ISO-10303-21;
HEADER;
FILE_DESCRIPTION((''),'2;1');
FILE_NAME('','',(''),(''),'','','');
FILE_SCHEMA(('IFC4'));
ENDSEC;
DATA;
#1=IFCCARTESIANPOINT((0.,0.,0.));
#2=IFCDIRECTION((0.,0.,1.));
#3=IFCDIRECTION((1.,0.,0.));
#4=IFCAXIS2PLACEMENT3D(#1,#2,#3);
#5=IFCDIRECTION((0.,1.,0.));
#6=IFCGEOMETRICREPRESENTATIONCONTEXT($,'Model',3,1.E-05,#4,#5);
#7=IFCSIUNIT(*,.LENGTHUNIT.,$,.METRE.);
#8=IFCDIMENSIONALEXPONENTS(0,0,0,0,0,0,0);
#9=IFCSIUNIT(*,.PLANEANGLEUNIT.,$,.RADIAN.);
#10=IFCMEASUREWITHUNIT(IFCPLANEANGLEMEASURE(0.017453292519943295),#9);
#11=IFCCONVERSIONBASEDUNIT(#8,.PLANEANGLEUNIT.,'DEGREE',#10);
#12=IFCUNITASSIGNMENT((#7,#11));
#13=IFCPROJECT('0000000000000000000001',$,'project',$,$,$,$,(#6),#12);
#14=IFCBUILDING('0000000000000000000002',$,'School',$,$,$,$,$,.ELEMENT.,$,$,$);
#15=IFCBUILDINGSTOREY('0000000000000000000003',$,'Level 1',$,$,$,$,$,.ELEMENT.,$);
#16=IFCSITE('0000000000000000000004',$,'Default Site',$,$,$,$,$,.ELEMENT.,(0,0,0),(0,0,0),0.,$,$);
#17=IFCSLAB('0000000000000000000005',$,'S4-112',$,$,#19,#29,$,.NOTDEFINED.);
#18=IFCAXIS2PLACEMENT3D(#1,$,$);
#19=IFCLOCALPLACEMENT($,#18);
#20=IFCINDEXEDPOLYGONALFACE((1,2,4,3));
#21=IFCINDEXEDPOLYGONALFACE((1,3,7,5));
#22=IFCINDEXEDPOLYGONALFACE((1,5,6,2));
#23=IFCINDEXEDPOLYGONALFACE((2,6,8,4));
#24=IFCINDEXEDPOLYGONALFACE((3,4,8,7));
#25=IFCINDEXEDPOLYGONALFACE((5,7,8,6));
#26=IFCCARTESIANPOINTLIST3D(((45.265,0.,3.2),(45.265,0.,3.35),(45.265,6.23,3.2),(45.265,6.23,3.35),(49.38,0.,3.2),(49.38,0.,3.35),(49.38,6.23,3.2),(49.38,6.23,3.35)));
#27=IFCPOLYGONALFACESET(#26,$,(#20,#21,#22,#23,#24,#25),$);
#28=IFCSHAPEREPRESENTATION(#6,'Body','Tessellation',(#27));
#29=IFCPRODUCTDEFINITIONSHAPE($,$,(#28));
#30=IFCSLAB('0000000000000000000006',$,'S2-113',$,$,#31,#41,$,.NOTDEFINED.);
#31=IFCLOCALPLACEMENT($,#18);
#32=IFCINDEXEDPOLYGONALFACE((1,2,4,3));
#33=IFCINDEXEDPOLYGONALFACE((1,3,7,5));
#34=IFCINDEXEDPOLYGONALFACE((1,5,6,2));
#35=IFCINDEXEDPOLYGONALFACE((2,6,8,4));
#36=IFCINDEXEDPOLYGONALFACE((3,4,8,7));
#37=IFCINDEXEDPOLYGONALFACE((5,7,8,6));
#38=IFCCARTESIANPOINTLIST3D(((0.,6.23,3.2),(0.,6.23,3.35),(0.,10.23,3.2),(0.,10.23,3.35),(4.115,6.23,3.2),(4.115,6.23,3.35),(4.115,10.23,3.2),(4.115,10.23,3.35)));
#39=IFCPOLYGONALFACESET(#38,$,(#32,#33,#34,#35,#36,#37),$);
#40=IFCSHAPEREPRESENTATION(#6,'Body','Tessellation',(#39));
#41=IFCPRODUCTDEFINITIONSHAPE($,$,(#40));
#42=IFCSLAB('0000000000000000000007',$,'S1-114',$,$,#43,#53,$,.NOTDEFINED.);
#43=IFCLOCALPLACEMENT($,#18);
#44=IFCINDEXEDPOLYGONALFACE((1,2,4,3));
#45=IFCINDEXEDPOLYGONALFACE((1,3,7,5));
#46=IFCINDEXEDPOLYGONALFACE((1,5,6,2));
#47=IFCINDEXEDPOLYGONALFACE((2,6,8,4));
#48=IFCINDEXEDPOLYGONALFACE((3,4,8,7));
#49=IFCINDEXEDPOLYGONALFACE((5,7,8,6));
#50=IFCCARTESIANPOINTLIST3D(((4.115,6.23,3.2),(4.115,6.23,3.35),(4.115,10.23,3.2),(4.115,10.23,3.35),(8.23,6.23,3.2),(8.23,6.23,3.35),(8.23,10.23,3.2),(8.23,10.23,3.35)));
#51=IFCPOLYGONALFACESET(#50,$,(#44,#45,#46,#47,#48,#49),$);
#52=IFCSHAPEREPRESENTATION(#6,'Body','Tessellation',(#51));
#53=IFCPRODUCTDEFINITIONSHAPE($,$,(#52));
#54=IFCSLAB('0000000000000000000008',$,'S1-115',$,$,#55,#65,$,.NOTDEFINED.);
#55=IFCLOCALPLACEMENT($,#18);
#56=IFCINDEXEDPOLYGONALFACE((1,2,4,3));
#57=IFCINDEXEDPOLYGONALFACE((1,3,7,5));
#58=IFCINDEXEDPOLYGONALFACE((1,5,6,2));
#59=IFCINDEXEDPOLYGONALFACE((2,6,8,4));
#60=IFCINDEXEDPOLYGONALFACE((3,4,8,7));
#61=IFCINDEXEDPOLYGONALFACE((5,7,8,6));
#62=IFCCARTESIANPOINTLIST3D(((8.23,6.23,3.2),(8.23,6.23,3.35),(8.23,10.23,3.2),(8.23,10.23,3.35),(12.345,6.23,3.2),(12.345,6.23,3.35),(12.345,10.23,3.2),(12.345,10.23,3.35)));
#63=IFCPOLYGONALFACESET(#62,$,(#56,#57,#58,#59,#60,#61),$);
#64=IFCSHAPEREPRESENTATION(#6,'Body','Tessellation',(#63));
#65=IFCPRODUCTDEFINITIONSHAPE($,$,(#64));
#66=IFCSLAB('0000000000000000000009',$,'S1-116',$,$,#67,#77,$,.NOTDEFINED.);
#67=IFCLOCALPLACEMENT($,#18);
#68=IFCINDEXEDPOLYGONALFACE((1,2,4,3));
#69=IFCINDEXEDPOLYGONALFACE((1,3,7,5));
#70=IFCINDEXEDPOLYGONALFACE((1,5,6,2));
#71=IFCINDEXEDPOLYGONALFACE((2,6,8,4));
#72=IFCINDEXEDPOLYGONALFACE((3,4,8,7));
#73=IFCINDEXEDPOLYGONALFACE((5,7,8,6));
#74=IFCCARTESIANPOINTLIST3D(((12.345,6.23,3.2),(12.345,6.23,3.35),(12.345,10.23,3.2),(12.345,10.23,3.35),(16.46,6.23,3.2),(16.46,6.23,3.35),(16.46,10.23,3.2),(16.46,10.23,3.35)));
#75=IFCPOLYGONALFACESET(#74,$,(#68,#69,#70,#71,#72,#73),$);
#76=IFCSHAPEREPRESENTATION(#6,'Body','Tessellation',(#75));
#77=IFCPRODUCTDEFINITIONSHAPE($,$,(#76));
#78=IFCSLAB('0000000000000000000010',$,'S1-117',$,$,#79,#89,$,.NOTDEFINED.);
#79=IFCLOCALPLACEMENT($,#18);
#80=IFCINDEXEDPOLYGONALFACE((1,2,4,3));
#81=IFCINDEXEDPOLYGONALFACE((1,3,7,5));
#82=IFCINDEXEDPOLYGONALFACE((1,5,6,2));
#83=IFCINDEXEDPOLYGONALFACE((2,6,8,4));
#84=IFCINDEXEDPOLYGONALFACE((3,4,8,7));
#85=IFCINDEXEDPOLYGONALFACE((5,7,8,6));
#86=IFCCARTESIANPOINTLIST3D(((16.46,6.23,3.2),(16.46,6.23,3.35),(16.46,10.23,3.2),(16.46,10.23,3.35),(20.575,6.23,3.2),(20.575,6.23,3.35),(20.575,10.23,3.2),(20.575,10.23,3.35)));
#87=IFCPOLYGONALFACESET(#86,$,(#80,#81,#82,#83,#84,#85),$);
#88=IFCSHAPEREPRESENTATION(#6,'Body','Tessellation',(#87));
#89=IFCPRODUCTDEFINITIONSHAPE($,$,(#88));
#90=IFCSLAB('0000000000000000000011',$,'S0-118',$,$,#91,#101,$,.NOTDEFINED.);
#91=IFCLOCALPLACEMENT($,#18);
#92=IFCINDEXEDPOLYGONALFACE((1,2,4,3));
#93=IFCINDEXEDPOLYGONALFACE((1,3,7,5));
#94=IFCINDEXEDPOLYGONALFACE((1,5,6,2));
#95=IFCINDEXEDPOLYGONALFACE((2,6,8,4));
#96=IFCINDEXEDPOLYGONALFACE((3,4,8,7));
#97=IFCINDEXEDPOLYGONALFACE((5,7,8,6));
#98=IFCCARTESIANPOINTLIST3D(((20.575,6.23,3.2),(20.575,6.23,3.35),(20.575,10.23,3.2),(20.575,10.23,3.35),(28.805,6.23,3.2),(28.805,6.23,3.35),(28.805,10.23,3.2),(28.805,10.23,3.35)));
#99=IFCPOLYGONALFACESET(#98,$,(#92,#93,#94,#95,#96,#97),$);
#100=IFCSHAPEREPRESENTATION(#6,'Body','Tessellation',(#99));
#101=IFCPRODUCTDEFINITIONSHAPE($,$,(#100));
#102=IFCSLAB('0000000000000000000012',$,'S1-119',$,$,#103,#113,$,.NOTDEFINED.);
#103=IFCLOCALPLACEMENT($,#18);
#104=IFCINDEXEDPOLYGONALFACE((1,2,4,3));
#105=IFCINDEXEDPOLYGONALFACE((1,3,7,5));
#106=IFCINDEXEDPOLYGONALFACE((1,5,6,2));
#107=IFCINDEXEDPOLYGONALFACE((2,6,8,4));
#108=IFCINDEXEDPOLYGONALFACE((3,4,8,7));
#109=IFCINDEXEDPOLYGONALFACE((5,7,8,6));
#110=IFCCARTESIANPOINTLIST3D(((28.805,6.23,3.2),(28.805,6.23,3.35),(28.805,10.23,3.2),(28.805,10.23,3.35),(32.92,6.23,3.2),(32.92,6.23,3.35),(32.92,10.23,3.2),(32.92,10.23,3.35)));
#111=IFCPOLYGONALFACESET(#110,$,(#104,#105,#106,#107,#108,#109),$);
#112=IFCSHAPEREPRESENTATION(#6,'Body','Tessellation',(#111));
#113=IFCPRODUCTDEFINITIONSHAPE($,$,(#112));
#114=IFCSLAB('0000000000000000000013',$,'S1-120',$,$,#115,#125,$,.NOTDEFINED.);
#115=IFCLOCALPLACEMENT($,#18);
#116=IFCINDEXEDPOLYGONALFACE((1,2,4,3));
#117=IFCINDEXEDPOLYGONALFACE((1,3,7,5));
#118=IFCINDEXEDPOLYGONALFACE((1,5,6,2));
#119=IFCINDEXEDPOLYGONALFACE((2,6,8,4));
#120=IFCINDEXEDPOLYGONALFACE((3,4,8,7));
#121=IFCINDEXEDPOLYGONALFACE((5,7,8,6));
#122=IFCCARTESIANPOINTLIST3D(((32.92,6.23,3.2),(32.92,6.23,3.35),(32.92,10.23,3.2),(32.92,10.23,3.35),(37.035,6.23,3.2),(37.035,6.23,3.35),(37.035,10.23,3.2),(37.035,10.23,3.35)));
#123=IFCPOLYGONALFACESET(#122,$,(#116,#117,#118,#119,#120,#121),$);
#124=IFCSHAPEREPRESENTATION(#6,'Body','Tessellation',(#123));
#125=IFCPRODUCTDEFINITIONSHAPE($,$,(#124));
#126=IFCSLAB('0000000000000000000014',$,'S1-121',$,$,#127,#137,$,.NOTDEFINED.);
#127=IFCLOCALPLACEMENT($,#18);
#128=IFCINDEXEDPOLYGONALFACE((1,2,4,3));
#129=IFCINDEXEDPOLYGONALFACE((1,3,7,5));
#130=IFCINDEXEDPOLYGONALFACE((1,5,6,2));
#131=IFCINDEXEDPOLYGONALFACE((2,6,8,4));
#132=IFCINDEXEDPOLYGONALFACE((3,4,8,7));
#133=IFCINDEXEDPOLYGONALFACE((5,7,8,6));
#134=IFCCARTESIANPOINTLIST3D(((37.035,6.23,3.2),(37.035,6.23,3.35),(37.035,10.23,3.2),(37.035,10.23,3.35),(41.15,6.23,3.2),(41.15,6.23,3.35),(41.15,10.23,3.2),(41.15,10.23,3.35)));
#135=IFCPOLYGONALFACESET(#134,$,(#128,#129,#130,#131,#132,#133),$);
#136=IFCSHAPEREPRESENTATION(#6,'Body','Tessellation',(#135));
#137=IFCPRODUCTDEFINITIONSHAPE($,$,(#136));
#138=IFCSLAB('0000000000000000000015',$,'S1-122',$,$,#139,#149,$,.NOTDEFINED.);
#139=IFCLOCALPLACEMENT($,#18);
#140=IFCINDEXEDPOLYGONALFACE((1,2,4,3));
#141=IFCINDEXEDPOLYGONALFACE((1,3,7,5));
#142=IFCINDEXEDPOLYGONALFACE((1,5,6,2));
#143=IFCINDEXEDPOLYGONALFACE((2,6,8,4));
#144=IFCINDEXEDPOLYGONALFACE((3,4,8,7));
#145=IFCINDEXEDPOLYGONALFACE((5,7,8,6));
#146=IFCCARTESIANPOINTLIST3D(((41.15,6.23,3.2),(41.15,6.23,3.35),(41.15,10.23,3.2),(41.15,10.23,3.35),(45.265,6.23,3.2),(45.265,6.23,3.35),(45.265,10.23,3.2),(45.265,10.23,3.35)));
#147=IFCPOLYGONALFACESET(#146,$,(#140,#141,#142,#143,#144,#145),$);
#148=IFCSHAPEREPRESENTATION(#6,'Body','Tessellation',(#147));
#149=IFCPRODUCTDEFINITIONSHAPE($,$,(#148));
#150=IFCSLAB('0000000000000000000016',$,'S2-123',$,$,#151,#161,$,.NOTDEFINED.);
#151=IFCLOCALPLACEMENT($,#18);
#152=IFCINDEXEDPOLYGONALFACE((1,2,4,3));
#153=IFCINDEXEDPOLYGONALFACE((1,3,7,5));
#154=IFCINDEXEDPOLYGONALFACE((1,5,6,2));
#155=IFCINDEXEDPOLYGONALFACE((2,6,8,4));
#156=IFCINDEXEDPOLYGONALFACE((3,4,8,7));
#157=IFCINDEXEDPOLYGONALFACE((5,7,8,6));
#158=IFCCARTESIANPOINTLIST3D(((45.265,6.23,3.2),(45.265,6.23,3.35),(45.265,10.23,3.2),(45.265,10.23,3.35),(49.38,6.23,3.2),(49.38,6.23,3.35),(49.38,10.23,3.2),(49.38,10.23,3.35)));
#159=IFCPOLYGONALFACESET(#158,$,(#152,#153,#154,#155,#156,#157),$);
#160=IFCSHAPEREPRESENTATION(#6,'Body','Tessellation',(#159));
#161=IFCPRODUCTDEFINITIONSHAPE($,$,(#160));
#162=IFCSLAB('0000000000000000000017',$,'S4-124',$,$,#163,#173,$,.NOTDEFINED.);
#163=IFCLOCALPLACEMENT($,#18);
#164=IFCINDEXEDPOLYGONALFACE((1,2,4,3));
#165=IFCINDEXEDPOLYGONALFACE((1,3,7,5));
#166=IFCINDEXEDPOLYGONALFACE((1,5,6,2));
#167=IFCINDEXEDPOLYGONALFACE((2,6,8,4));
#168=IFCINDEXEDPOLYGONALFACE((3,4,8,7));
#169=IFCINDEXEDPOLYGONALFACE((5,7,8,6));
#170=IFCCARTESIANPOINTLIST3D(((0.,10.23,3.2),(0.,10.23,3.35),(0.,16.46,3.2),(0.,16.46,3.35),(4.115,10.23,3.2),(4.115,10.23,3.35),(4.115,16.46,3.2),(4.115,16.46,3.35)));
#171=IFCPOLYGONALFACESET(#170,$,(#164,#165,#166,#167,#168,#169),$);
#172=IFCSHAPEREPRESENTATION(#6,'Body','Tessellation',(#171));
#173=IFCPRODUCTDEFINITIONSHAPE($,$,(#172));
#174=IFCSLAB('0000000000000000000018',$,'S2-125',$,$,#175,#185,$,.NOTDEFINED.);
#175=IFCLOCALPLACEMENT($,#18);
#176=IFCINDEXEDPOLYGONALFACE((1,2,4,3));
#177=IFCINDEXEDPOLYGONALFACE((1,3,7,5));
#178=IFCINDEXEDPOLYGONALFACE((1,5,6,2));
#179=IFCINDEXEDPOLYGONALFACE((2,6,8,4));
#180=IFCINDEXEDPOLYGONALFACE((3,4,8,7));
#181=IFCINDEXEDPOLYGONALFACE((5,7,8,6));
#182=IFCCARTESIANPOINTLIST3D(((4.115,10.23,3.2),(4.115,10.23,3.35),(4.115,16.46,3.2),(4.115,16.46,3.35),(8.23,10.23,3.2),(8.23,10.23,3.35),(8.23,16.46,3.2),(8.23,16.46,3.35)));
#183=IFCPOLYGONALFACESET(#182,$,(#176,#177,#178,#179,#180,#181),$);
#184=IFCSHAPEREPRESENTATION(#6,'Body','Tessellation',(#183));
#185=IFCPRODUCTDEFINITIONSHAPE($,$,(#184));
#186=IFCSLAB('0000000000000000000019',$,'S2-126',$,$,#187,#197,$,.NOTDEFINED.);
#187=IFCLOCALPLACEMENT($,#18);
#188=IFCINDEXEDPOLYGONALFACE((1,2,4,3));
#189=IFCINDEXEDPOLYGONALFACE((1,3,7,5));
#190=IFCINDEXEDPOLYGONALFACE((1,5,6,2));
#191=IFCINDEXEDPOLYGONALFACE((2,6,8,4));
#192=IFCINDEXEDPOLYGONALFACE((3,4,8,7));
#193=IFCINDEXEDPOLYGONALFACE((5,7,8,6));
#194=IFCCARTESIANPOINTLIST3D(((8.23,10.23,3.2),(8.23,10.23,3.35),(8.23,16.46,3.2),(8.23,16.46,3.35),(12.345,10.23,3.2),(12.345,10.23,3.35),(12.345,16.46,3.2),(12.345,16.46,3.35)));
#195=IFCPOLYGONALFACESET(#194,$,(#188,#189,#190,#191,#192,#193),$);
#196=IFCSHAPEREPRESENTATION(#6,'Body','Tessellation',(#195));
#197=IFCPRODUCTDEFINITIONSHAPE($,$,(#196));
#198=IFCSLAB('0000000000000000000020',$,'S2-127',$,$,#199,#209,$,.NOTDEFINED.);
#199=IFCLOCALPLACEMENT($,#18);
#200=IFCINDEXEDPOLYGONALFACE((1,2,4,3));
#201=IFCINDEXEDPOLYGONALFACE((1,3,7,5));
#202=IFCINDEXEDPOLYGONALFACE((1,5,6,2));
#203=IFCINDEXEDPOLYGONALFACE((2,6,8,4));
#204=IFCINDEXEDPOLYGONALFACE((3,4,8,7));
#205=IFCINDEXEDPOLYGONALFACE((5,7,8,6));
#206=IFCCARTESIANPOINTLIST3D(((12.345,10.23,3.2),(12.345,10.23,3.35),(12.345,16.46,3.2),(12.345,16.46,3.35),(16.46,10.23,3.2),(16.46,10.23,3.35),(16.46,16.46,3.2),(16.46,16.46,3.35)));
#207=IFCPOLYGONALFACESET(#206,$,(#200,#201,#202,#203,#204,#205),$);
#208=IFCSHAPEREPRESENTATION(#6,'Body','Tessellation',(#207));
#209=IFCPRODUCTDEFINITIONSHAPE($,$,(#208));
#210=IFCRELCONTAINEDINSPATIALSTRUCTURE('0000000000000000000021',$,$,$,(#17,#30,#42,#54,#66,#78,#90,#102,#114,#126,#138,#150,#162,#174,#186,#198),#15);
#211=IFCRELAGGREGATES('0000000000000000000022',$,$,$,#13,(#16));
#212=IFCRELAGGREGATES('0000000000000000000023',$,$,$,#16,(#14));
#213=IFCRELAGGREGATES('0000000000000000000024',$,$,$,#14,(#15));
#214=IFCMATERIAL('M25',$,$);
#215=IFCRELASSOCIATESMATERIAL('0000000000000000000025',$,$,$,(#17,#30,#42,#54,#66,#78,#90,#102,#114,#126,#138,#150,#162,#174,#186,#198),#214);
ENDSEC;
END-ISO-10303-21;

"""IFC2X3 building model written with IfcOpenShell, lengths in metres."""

from ifc_helpers import new_model, entity, si_unit, converted_unit, direction, frame, frame_2d, origin_with_axes, place, context, project, spatial, rectangle, extrude, material, element, save


model = new_model("IFC2X3")

# Units and contexts
model_context = context("Model", 3, precision=1e-05, world=origin_with_axes(), true_north=direction((0.0, 1.0, 0.0)))
ifc_project = project(units=[si_unit("LENGTHUNIT", "METRE"), converted_unit("PLANEANGLEUNIT", "DEGREE", entity("IfcPlaneAngleMeasure", 0.017453292519943295), si_unit("PLANEANGLEUNIT", "RADIAN"), dimensions=[0, 0, 0, 0, 0, 0, 0])], contexts=[model_context])

# Site, building, storey
site = spatial("IfcSite", under=ifc_project, Name="Default Site", CompositionType="ELEMENT", RefLatitude=(0, 0, 0), RefLongitude=(0, 0, 0), RefElevation=0.0)
building = spatial("IfcBuilding", under=site, Name="School", CompositionType="ELEMENT")
storey = spatial("IfcBuildingStorey", under=building, Name="Level 1", CompositionType="ELEMENT")

# Slabs
ifc_material = material(Name="M25")
placement = place(None, origin_with_axes())
element("IfcSlab", 1, at=placement, inside=storey, material=ifc_material, Name="S4-112", PredefinedType="NOTDEFINED", context=model_context, shape_type="SweptSolid", body=[
    extrude(rectangle(XDim=4.115, YDim=6.23, at=frame_2d((0.0, 0.0), x_axis=(1.0, 0.0, 0.0))), frame((47.3225, 3.115, 3.2), z_axis=(0.0, 0.0, 1.0), x_axis=(1.0, 0.0, 0.0)), (0.0, 0.0, 1.0), 0.15),
])
element("IfcSlab", 2, at=placement, inside=storey, material=ifc_material, Name="S2-113", PredefinedType="NOTDEFINED", context=model_context, shape_type="SweptSolid", body=[
    extrude(rectangle(XDim=4.115, YDim=4.0, at=frame_2d((0.0, 0.0), x_axis=(1.0, 0.0, 0.0))), frame((2.0575, 8.23, 3.2), z_axis=(0.0, 0.0, 1.0), x_axis=(1.0, 0.0, 0.0)), (0.0, 0.0, 1.0), 0.15),
])
element("IfcSlab", 3, at=placement, inside=storey, material=ifc_material, Name="S1-114", PredefinedType="NOTDEFINED", context=model_context, shape_type="SweptSolid", body=[
    extrude(rectangle(XDim=4.115, YDim=4.0, at=frame_2d((0.0, 0.0), x_axis=(1.0, 0.0, 0.0))), frame((6.1725, 8.23, 3.2), z_axis=(0.0, 0.0, 1.0), x_axis=(1.0, 0.0, 0.0)), (0.0, 0.0, 1.0), 0.15),
])
element("IfcSlab", 4, at=placement, inside=storey, material=ifc_material, Name="S1-115", PredefinedType="NOTDEFINED", context=model_context, shape_type="SweptSolid", body=[
    extrude(rectangle(XDim=4.115, YDim=4.0, at=frame_2d((0.0, 0.0), x_axis=(1.0, 0.0, 0.0))), frame((10.2875, 8.23, 3.2), z_axis=(0.0, 0.0, 1.0), x_axis=(1.0, 0.0, 0.0)), (0.0, 0.0, 1.0), 0.15),
])
element("IfcSlab", 5, at=placement, inside=storey, material=ifc_material, Name="S1-116", PredefinedType="NOTDEFINED", context=model_context, shape_type="SweptSolid", body=[
    extrude(rectangle(XDim=4.115, YDim=4.0, at=frame_2d((0.0, 0.0), x_axis=(1.0, 0.0, 0.0))), frame((14.4025, 8.23, 3.2), z_axis=(0.0, 0.0, 1.0), x_axis=(1.0, 0.0, 0.0)), (0.0, 0.0, 1.0), 0.15),
])
element("IfcSlab", 6, at=placement, inside=storey, material=ifc_material, Name="S1-117", PredefinedType="NOTDEFINED", context=model_context, shape_type="SweptSolid", body=[
    extrude(rectangle(XDim=4.115, YDim=4.0, at=frame_2d((0.0, 0.0), x_axis=(1.0, 0.0, 0.0))), frame((18.5175, 8.23, 3.2), z_axis=(0.0, 0.0, 1.0), x_axis=(1.0, 0.0, 0.0)), (0.0, 0.0, 1.0), 0.15),
])
element("IfcSlab", 7, at=placement, inside=storey, material=ifc_material, Name="S0-118", PredefinedType="NOTDEFINED", context=model_context, shape_type="SweptSolid", body=[
    extrude(rectangle(XDim=8.23, YDim=4.0, at=frame_2d((0.0, 0.0), x_axis=(1.0, 0.0, 0.0))), frame((24.69, 8.23, 3.2), z_axis=(0.0, 0.0, 1.0), x_axis=(1.0, 0.0, 0.0)), (0.0, 0.0, 1.0), 0.15),
])
element("IfcSlab", 8, at=placement, inside=storey, material=ifc_material, Name="S1-119", PredefinedType="NOTDEFINED", context=model_context, shape_type="SweptSolid", body=[
    extrude(rectangle(XDim=4.115, YDim=4.0, at=frame_2d((0.0, 0.0), x_axis=(1.0, 0.0, 0.0))), frame((30.8625, 8.23, 3.2), z_axis=(0.0, 0.0, 1.0), x_axis=(1.0, 0.0, 0.0)), (0.0, 0.0, 1.0), 0.15),
])
element("IfcSlab", 9, at=placement, inside=storey, material=ifc_material, Name="S1-120", PredefinedType="NOTDEFINED", context=model_context, shape_type="SweptSolid", body=[
    extrude(rectangle(XDim=4.115, YDim=4.0, at=frame_2d((0.0, 0.0), x_axis=(1.0, 0.0, 0.0))), frame((34.9775, 8.23, 3.2), z_axis=(0.0, 0.0, 1.0), x_axis=(1.0, 0.0, 0.0)), (0.0, 0.0, 1.0), 0.15),
])
element("IfcSlab", 10, at=placement, inside=storey, material=ifc_material, Name="S1-121", PredefinedType="NOTDEFINED", context=model_context, shape_type="SweptSolid", body=[
    extrude(rectangle(XDim=4.115, YDim=4.0, at=frame_2d((0.0, 0.0), x_axis=(1.0, 0.0, 0.0))), frame((39.0925, 8.23, 3.2), z_axis=(0.0, 0.0, 1.0), x_axis=(1.0, 0.0, 0.0)), (0.0, 0.0, 1.0), 0.15),
])
element("IfcSlab", 11, at=placement, inside=storey, material=ifc_material, Name="S1-122", PredefinedType="NOTDEFINED", context=model_context, shape_type="SweptSolid", body=[
    extrude(rectangle(XDim=4.115, YDim=4.0, at=frame_2d((0.0, 0.0), x_axis=(1.0, 0.0, 0.0))), frame((43.2075, 8.23, 3.2), z_axis=(0.0, 0.0, 1.0), x_axis=(1.0, 0.0, 0.0)), (0.0, 0.0, 1.0), 0.15),
])
element("IfcSlab", 12, at=placement, inside=storey, material=ifc_material, Name="S2-123", PredefinedType="NOTDEFINED", context=model_context, shape_type="SweptSolid", body=[
    extrude(rectangle(XDim=4.115, YDim=4.0, at=frame_2d((0.0, 0.0), x_axis=(1.0, 0.0, 0.0))), frame((47.3225, 8.23, 3.2), z_axis=(0.0, 0.0, 1.0), x_axis=(1.0, 0.0, 0.0)), (0.0, 0.0, 1.0), 0.15),
])
element("IfcSlab", 13, at=placement, inside=storey, material=ifc_material, Name="S4-124", PredefinedType="NOTDEFINED", context=model_context, shape_type="SweptSolid", body=[
    extrude(rectangle(XDim=4.115, YDim=6.23, at=frame_2d((0.0, 0.0), x_axis=(1.0, 0.0, 0.0))), frame((2.0575, 13.345, 3.2), z_axis=(0.0, 0.0, 1.0), x_axis=(1.0, 0.0, 0.0)), (0.0, 0.0, 1.0), 0.15),
])
element("IfcSlab", 14, at=placement, inside=storey, material=ifc_material, Name="S2-125", PredefinedType="NOTDEFINED", context=model_context, shape_type="SweptSolid", body=[
    extrude(rectangle(XDim=4.115, YDim=6.23, at=frame_2d((0.0, 0.0), x_axis=(1.0, 0.0, 0.0))), frame((6.1725, 13.345, 3.2), z_axis=(0.0, 0.0, 1.0), x_axis=(1.0, 0.0, 0.0)), (0.0, 0.0, 1.0), 0.15),
])
element("IfcSlab", 15, at=placement, inside=storey, material=ifc_material, Name="S2-126", PredefinedType="NOTDEFINED", context=model_context, shape_type="SweptSolid", body=[
    extrude(rectangle(XDim=4.115, YDim=6.23, at=frame_2d((0.0, 0.0), x_axis=(1.0, 0.0, 0.0))), frame((10.2875, 13.345, 3.2), z_axis=(0.0, 0.0, 1.0), x_axis=(1.0, 0.0, 0.0)), (0.0, 0.0, 1.0), 0.15),
])
element("IfcSlab", 16, at=placement, inside=storey, material=ifc_material, Name="S2-127", PredefinedType="NOTDEFINED", context=model_context, shape_type="SweptSolid", body=[
    extrude(rectangle(XDim=4.115, YDim=6.23, at=frame_2d((0.0, 0.0), x_axis=(1.0, 0.0, 0.0))), frame((14.4025, 13.345, 3.2), z_axis=(0.0, 0.0, 1.0), x_axis=(1.0, 0.0, 0.0)), (0.0, 0.0, 1.0), 0.15),
])

save(model, "model.ifc")
